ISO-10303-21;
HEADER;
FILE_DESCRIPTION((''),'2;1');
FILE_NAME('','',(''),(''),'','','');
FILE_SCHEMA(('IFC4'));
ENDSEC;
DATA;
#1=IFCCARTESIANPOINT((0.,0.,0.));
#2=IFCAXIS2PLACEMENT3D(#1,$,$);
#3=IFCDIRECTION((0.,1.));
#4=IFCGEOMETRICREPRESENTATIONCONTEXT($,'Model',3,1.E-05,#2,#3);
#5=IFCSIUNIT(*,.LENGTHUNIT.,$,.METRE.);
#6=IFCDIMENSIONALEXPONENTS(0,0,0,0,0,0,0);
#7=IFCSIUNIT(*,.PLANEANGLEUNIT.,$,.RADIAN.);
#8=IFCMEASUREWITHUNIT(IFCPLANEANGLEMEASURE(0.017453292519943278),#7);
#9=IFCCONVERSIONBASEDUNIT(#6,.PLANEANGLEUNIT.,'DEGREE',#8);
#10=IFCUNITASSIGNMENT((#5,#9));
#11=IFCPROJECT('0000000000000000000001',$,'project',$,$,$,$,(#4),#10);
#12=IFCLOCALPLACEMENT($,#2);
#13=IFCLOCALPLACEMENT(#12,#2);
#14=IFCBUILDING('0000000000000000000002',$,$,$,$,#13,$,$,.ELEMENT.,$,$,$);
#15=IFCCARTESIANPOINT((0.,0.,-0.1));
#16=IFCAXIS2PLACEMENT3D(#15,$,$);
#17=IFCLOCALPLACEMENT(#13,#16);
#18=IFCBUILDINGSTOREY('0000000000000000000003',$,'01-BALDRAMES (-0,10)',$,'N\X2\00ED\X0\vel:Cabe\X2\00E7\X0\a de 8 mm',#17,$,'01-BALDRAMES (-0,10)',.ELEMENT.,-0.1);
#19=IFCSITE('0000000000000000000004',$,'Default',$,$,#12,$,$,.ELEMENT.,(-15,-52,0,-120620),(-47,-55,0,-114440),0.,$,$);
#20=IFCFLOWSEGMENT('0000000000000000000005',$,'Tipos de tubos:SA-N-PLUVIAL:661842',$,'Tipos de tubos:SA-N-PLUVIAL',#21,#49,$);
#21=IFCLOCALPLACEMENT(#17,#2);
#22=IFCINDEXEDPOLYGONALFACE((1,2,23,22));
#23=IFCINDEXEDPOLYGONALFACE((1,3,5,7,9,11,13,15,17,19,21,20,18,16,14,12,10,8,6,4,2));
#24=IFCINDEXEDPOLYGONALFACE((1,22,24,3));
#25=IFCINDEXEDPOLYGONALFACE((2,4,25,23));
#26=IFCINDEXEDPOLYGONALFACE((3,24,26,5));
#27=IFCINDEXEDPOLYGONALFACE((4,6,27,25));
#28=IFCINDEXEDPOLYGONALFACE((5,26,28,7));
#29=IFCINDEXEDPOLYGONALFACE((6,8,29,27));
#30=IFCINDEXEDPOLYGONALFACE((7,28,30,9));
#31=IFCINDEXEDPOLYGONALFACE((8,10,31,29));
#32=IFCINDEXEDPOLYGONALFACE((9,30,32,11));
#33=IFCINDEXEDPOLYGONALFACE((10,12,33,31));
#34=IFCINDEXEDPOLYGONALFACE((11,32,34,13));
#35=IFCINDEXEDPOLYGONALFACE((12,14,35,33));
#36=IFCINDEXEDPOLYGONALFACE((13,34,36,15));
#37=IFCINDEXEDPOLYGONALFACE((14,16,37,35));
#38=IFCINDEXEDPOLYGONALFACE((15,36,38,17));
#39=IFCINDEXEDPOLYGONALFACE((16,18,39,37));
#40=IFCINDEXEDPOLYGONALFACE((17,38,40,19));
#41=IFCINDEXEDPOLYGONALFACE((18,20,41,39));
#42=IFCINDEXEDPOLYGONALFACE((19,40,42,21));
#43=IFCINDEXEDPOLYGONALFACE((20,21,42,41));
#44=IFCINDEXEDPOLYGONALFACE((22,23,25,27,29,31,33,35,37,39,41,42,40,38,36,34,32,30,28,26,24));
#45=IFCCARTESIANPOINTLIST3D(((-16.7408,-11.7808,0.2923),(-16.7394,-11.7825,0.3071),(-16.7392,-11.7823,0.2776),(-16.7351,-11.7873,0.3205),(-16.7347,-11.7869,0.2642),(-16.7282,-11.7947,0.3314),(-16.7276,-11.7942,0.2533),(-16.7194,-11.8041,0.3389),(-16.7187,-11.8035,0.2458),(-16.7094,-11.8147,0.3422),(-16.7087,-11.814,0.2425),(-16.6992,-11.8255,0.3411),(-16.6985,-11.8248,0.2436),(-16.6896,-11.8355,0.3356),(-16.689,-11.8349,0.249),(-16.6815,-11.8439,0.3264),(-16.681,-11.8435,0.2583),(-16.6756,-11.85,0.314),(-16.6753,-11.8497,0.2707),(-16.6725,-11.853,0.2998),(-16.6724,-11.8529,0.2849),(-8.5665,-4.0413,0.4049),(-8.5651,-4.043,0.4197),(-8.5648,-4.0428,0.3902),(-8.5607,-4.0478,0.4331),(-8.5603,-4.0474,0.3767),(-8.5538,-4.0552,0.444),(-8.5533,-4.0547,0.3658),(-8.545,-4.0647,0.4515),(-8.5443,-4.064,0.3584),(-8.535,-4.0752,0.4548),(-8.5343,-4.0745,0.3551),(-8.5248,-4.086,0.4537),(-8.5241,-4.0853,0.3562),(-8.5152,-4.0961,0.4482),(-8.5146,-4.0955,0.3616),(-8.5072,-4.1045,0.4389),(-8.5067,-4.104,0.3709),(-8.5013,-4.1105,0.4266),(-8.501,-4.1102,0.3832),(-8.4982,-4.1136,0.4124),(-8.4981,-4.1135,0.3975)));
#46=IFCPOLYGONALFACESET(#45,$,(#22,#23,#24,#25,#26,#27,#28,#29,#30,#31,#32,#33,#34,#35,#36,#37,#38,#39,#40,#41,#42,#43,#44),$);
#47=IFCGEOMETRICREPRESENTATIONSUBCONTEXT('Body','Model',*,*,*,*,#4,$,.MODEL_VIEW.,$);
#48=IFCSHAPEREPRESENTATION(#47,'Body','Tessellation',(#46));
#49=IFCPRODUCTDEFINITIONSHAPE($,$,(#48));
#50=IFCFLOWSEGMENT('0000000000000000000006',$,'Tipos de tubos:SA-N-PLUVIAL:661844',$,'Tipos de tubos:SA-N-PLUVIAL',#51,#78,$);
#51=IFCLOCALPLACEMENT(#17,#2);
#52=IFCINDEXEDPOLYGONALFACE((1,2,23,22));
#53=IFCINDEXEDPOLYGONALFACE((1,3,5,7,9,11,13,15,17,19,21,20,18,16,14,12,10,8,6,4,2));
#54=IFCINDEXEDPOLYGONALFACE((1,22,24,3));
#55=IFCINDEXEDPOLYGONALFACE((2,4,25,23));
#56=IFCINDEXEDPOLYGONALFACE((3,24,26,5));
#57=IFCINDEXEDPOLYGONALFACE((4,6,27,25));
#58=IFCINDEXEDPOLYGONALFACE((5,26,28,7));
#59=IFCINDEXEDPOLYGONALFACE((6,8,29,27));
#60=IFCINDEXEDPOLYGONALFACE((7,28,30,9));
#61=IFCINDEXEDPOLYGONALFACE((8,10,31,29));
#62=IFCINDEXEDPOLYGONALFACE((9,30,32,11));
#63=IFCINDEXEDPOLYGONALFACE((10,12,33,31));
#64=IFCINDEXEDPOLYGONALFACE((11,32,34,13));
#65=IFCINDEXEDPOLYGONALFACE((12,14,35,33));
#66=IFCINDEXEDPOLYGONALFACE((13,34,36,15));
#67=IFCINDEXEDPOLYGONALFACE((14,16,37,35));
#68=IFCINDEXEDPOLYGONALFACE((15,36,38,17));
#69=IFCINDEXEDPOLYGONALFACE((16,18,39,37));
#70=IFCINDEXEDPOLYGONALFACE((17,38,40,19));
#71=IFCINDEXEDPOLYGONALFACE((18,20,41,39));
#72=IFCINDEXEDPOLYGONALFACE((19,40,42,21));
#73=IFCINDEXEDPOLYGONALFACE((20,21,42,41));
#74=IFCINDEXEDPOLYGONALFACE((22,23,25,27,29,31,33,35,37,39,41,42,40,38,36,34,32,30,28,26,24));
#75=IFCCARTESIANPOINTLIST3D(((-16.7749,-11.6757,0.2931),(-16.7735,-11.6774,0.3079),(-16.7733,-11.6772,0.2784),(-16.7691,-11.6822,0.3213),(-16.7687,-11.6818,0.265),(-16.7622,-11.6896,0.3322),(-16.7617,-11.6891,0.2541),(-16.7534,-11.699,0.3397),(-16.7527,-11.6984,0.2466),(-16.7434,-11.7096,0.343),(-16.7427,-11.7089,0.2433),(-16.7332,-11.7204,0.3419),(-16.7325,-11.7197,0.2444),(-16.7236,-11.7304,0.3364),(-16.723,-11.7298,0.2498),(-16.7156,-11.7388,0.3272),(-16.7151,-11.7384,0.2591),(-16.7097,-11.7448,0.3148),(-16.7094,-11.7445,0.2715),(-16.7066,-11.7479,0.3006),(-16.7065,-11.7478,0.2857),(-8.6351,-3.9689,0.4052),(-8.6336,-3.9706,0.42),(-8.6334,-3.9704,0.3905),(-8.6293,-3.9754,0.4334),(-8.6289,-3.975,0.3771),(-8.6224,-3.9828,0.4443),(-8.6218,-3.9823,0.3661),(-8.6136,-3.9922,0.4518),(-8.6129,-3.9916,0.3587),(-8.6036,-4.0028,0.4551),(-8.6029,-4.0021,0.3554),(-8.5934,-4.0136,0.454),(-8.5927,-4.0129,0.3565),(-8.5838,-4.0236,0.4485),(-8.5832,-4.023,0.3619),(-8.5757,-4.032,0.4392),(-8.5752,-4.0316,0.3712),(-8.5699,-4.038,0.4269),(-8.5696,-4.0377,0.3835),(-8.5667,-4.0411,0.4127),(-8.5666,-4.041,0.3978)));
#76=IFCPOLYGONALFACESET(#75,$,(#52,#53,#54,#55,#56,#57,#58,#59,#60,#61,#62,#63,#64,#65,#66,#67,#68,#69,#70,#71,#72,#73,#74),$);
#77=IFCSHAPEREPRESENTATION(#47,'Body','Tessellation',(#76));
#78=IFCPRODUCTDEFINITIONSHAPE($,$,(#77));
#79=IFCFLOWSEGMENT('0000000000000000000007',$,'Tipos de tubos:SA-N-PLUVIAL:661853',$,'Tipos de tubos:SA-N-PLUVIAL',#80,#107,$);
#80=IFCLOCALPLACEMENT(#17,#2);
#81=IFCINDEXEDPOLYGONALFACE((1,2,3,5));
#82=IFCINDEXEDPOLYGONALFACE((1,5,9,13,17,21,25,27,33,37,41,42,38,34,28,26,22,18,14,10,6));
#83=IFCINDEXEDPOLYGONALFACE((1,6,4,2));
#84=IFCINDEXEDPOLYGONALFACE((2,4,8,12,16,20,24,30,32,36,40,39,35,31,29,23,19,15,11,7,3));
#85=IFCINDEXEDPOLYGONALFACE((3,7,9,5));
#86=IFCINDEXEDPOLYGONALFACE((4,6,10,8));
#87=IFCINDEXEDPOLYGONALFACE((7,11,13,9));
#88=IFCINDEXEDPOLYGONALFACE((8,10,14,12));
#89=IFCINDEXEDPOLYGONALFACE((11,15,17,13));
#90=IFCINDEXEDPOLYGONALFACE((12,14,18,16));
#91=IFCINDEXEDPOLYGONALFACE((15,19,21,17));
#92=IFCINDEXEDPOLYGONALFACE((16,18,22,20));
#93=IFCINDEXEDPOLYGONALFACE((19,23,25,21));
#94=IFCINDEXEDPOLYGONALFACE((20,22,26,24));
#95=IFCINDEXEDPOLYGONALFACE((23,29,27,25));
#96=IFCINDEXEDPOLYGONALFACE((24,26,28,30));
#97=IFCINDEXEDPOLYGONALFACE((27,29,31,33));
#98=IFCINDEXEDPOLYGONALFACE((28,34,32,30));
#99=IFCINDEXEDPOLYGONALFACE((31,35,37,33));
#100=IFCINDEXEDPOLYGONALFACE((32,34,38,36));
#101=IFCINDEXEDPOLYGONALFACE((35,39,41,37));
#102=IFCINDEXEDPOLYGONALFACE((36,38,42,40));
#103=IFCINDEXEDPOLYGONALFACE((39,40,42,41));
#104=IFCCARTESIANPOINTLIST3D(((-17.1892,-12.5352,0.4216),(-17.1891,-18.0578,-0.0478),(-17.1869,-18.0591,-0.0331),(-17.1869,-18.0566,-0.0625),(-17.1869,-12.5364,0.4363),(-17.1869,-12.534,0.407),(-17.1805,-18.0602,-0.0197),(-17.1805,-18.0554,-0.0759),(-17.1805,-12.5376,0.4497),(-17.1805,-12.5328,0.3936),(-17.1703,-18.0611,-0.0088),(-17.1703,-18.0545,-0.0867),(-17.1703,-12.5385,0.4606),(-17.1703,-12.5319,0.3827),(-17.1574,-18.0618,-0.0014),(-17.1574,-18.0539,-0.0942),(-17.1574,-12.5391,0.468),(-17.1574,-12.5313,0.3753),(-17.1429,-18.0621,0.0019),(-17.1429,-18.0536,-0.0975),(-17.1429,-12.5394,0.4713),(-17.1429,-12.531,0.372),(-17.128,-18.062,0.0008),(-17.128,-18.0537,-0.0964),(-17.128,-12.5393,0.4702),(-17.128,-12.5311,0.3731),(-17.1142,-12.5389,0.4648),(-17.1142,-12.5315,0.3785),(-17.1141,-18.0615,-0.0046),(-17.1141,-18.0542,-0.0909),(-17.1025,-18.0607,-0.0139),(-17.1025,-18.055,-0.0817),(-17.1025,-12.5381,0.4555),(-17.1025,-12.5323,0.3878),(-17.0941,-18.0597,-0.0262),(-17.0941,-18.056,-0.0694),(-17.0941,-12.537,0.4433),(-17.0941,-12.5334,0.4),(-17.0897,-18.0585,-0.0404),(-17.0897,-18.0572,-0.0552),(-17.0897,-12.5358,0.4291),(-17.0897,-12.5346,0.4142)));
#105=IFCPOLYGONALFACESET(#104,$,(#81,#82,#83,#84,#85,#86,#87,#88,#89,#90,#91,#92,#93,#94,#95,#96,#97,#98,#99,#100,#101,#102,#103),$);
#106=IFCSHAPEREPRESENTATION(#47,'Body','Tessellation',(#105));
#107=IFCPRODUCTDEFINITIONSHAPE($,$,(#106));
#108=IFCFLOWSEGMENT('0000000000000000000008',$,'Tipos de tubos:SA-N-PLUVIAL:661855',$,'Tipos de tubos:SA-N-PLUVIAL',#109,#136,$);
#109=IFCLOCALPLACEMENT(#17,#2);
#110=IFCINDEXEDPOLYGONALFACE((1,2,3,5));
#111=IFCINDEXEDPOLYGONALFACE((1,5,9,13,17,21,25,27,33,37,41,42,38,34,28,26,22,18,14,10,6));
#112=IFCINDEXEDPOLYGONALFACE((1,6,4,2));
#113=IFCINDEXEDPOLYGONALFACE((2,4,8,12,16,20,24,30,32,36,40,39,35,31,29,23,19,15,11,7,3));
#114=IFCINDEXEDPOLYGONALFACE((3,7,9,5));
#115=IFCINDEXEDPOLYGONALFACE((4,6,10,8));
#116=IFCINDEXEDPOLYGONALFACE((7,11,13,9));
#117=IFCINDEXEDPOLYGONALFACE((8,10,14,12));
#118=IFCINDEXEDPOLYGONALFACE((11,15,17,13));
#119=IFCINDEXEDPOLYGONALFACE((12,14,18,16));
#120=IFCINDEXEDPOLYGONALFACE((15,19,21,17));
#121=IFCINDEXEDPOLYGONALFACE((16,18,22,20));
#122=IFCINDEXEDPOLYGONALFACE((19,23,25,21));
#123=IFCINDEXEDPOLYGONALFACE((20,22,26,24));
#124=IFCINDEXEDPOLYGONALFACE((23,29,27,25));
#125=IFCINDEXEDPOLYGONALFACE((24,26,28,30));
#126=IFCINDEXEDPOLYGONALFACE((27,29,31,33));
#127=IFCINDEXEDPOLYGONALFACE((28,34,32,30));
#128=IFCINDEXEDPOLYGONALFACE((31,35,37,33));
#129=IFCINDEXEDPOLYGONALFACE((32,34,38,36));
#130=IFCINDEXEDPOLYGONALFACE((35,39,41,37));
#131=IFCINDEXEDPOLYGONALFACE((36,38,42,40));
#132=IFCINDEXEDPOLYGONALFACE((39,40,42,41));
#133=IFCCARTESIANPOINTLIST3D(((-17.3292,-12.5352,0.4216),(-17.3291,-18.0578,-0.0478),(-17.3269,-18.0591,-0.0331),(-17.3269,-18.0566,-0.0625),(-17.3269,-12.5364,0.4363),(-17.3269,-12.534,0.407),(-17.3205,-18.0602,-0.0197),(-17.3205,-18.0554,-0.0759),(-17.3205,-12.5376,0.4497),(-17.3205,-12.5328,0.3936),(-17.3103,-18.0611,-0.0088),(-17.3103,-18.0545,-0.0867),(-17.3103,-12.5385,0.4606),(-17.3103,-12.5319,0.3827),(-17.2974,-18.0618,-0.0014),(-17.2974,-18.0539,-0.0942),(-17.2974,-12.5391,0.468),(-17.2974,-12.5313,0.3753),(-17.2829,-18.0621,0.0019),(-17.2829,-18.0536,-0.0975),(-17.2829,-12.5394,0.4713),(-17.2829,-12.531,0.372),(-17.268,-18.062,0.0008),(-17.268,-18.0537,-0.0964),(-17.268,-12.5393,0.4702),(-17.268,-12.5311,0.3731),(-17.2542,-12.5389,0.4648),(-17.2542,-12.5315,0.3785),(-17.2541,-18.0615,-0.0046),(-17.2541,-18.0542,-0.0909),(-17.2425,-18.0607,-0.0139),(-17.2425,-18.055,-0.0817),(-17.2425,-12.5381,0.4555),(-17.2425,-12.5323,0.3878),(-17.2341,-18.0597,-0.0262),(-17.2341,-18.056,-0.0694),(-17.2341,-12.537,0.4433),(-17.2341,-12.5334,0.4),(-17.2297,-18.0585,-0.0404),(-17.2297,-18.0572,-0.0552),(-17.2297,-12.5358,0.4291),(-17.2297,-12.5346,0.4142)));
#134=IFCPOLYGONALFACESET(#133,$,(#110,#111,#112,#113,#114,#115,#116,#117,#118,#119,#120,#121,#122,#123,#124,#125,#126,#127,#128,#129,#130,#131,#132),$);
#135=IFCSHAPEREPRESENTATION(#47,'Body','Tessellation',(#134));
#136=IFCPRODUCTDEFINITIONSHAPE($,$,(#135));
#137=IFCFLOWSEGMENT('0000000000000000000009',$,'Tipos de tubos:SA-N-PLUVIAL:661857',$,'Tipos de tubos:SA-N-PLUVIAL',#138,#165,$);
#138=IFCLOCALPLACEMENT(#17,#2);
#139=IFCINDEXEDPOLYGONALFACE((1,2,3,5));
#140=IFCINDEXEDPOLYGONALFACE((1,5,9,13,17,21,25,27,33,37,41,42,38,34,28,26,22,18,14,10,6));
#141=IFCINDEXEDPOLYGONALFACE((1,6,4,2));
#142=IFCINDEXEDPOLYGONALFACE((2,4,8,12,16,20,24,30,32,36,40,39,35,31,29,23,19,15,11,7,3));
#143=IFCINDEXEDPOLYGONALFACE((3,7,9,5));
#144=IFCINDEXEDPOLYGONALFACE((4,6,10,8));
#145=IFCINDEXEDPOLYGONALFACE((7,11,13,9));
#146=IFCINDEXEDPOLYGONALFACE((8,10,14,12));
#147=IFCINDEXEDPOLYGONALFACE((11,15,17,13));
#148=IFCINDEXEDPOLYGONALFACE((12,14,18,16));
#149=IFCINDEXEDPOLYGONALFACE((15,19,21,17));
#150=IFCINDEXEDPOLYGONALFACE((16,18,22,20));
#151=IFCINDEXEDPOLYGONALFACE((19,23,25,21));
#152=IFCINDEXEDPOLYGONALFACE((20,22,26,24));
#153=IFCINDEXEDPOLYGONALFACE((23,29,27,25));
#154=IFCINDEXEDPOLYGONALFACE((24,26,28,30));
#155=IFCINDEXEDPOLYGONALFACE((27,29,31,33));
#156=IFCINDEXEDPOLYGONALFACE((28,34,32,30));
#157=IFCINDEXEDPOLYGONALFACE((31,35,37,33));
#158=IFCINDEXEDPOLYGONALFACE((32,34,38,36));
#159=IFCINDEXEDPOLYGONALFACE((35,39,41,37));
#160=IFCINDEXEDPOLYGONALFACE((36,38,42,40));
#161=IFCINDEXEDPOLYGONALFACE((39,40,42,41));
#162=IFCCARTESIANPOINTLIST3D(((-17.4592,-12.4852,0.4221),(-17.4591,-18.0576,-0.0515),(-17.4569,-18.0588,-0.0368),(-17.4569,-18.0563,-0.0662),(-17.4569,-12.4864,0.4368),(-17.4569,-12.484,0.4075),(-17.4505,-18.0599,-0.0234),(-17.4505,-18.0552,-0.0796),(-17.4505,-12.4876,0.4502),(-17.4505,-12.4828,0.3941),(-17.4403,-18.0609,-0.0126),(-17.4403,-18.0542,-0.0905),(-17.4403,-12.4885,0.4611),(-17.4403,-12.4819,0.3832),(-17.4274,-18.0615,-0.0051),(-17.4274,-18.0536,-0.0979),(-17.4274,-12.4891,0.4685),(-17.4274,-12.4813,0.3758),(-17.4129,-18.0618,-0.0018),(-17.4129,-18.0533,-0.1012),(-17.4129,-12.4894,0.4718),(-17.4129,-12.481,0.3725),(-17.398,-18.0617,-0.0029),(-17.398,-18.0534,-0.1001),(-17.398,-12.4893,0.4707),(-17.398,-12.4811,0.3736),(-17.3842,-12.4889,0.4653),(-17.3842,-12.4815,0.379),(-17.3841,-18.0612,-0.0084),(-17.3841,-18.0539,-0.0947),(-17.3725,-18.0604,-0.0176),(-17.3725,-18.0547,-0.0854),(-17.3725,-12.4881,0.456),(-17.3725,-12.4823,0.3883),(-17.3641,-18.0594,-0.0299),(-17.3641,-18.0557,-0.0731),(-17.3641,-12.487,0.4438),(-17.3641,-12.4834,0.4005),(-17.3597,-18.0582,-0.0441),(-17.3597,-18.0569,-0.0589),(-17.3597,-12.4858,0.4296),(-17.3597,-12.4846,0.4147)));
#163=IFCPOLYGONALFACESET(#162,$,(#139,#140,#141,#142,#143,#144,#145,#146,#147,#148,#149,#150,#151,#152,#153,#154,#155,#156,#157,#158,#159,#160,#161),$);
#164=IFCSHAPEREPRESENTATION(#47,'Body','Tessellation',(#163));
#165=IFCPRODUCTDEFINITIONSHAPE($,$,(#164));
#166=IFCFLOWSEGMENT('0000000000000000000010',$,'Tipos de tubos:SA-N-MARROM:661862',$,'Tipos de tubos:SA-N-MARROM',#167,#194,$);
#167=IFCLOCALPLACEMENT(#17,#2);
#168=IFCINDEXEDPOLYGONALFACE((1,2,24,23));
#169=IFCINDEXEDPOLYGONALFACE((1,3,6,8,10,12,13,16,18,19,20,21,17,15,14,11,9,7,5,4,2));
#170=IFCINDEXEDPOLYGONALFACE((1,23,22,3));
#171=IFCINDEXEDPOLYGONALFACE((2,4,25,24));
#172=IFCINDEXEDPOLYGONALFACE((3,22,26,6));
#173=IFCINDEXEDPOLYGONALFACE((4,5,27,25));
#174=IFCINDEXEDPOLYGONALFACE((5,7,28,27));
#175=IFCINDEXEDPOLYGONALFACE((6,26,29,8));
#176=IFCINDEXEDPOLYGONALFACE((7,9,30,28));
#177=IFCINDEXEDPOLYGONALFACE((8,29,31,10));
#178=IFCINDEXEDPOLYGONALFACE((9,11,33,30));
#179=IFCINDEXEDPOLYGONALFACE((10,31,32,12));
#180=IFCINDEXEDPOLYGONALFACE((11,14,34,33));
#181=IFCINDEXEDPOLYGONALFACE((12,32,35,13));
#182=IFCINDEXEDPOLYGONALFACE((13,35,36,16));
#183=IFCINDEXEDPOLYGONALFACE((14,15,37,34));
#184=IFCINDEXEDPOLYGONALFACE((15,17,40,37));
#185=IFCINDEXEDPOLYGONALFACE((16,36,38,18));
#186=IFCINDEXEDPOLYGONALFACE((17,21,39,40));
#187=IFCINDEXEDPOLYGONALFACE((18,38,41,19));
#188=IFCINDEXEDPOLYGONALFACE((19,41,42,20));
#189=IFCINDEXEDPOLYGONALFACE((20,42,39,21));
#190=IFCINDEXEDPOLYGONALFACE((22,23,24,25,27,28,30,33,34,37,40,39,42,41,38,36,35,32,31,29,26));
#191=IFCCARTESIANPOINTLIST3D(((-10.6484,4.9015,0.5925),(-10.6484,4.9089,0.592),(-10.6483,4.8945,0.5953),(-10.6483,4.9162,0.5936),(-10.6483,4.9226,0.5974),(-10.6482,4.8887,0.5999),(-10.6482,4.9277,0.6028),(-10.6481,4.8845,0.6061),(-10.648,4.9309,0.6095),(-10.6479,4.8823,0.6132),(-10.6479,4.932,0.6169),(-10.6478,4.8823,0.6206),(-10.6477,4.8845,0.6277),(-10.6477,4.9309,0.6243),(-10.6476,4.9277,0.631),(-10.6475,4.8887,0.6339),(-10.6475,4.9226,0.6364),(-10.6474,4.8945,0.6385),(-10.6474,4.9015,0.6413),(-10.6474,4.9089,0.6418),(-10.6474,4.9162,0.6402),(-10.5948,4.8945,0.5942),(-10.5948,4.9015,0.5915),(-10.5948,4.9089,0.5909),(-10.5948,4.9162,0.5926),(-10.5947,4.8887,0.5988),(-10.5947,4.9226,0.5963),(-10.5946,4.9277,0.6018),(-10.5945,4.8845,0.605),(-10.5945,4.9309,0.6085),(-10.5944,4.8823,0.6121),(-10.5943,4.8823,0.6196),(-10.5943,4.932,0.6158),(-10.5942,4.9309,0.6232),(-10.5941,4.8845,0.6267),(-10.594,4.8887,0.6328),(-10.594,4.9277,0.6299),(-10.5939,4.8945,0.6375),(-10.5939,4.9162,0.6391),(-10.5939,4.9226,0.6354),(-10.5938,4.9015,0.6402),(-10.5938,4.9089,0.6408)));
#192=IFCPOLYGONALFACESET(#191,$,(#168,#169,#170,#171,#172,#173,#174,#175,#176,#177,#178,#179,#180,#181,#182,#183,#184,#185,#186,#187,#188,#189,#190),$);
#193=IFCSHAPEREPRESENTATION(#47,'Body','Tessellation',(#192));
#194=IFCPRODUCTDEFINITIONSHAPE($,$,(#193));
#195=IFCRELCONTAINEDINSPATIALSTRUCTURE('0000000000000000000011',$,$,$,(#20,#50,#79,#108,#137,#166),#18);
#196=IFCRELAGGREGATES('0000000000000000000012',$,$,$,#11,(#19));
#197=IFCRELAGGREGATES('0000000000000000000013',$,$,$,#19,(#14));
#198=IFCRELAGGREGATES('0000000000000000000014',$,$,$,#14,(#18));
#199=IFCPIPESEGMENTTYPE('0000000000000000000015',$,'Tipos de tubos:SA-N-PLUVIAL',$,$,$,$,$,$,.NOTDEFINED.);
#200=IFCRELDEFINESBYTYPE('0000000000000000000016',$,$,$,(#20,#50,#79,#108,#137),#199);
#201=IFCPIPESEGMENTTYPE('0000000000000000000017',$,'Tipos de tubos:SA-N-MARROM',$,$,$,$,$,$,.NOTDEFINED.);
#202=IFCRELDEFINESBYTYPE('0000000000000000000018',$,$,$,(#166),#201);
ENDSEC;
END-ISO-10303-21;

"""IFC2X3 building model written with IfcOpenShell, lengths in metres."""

from ifc_helpers import new_model, entity, si_unit, converted_unit, direction, frame, frame_2d, origin, place, context, subcontext, project, spatial, circle, extrude, type_object, element, save


model = new_model("IFC2X3")

# Units and contexts
model_context = context("Model", 3, precision=1e-05, world=origin(), true_north=direction((0.0, 1.0)))
body_context = subcontext(model_context, "Body", "Model", "MODEL_VIEW")
ifc_project = project(units=[si_unit("LENGTHUNIT", "METRE"), converted_unit("PLANEANGLEUNIT", "DEGREE", entity("IfcPlaneAngleMeasure", 0.017453292519943278), si_unit("PLANEANGLEUNIT", "RADIAN"), dimensions=[0, 0, 0, 0, 0, 0, 0])], contexts=[model_context])

# Site, building, storey
site_placement = place(None, origin())
site = spatial("IfcSite", under=ifc_project, at=site_placement, Name="Default", CompositionType="ELEMENT", RefLatitude=(-15, -52, 0, -120620), RefLongitude=(-47, -55, 0, -114440), RefElevation=0.0)
building_placement = place(site_placement, origin())
building = spatial("IfcBuilding", under=site, at=building_placement, CompositionType="ELEMENT")
storey_placement = place(building_placement, frame((0.0, 0.0, -0.1)))
storey = spatial("IfcBuildingStorey", under=building, at=storey_placement, Name="01-BALDRAMES (-0,10)", ObjectType="Nível:Cabeça de 8 mm", LongName="01-BALDRAMES (-0,10)", CompositionType="ELEMENT", Elevation=-0.1)

# Flow segments
pipe_segment_type_1 = type_object("IfcPipeSegmentType", Name="Tipos de tubos:SA-N-PLUVIAL", PredefinedType="NOTDEFINED")
flow_segment_1_placement = place(storey_placement, origin())
element("IfcFlowSegment", 1, at=flow_segment_1_placement, inside=storey, type_object=pipe_segment_type_1, Name="Tipos de tubos:SA-N-PLUVIAL:661842", ObjectType="Tipos de tubos:SA-N-PLUVIAL", context=body_context, shape_type="SweptSolid", body=[
    extrude(circle(Radius=0.05, at=frame_2d((0.0, 0.0), x_axis=(1.0, 0.0))), frame((-16.7065, -11.8171, 0.2923), z_axis=(0.726122, 0.687493, 0.009999), x_axis=(-0.687528, 0.726158, 0.0)), (0.0, 0.0, 1.0), 11.2575),
])
flow_segment_2_placement = place(storey_placement, origin())
element("IfcFlowSegment", 2, at=flow_segment_2_placement, inside=storey, type_object=pipe_segment_type_1, Name="Tipos de tubos:SA-N-PLUVIAL:661844", ObjectType="Tipos de tubos:SA-N-PLUVIAL", context=body_context, shape_type="SweptSolid", body=[
    extrude(circle(Radius=0.05, at=frame_2d((0.0, 0.0), x_axis=(1.0, 0.0))), frame((-16.7405, -11.712, 0.2931), z_axis=(0.726122, 0.687493, 0.009999), x_axis=(-0.687528, 0.726158, 0.0)), (0.0, 0.0, 1.0), 11.21),
])
flow_segment_3_placement = place(storey_placement, origin())
element("IfcFlowSegment", 3, at=flow_segment_3_placement, inside=storey, type_object=pipe_segment_type_1, Name="Tipos de tubos:SA-N-PLUVIAL:661853", ObjectType="Tipos de tubos:SA-N-PLUVIAL", context=body_context, shape_type="SweptSolid", body=[
    extrude(circle(Radius=0.05, at=frame_2d((0.0, 0.0), x_axis=(1.0, 0.0))), frame((-17.1391, -18.0578, -0.0478), z_axis=(-0.000001, 0.996407, 0.084695), x_axis=(-1.0, -0.000001, 0.0)), (0.0, 0.0, 1.0), 5.5425),
])
flow_segment_4_placement = place(storey_placement, origin())
element("IfcFlowSegment", 4, at=flow_segment_4_placement, inside=storey, type_object=pipe_segment_type_1, Name="Tipos de tubos:SA-N-PLUVIAL:661855", ObjectType="Tipos de tubos:SA-N-PLUVIAL", context=body_context, shape_type="SweptSolid", body=[
    extrude(circle(Radius=0.05, at=frame_2d((0.0, 0.0), x_axis=(1.0, 0.0))), frame((-17.2791, -18.0578, -0.0478), z_axis=(-0.000001, 0.996407, 0.084695), x_axis=(-1.0, -0.000001, 0.0)), (0.0, 0.0, 1.0), 5.5425),
])
flow_segment_5_placement = place(storey_placement, origin())
element("IfcFlowSegment", 5, at=flow_segment_5_placement, inside=storey, type_object=pipe_segment_type_1, Name="Tipos de tubos:SA-N-PLUVIAL:661857", ObjectType="Tipos de tubos:SA-N-PLUVIAL", context=body_context, shape_type="SweptSolid", body=[
    extrude(circle(Radius=0.05, at=frame_2d((0.0, 0.0), x_axis=(1.0, 0.0))), frame((-17.4091, -18.0576, -0.0515), z_axis=(-0.000001, 0.996407, 0.084695), x_axis=(-1.0, -0.000001, 0.0)), (0.0, 0.0, 1.0), 5.5924),
])
pipe_segment_type_2 = type_object("IfcPipeSegmentType", Name="Tipos de tubos:SA-N-MARROM", PredefinedType="NOTDEFINED")
flow_segment_6_placement = place(storey_placement, origin())
element("IfcFlowSegment", 6, at=flow_segment_6_placement, inside=storey, type_object=pipe_segment_type_2, Name="Tipos de tubos:SA-N-MARROM:661862", ObjectType="Tipos de tubos:SA-N-MARROM", context=body_context, shape_type="SweptSolid", body=[
    extrude(circle(Radius=0.025, at=frame_2d((0.0, 0.0), x_axis=(1.0, 0.0))), frame((-10.5943, 4.907, 0.6158), z_axis=(-0.9998, -0.000001, 0.019996), x_axis=(-0.000001, 1.0, 0.0)), (0.0, 0.0, 1.0), 0.0536),
])

save(model, "model.ifc")
